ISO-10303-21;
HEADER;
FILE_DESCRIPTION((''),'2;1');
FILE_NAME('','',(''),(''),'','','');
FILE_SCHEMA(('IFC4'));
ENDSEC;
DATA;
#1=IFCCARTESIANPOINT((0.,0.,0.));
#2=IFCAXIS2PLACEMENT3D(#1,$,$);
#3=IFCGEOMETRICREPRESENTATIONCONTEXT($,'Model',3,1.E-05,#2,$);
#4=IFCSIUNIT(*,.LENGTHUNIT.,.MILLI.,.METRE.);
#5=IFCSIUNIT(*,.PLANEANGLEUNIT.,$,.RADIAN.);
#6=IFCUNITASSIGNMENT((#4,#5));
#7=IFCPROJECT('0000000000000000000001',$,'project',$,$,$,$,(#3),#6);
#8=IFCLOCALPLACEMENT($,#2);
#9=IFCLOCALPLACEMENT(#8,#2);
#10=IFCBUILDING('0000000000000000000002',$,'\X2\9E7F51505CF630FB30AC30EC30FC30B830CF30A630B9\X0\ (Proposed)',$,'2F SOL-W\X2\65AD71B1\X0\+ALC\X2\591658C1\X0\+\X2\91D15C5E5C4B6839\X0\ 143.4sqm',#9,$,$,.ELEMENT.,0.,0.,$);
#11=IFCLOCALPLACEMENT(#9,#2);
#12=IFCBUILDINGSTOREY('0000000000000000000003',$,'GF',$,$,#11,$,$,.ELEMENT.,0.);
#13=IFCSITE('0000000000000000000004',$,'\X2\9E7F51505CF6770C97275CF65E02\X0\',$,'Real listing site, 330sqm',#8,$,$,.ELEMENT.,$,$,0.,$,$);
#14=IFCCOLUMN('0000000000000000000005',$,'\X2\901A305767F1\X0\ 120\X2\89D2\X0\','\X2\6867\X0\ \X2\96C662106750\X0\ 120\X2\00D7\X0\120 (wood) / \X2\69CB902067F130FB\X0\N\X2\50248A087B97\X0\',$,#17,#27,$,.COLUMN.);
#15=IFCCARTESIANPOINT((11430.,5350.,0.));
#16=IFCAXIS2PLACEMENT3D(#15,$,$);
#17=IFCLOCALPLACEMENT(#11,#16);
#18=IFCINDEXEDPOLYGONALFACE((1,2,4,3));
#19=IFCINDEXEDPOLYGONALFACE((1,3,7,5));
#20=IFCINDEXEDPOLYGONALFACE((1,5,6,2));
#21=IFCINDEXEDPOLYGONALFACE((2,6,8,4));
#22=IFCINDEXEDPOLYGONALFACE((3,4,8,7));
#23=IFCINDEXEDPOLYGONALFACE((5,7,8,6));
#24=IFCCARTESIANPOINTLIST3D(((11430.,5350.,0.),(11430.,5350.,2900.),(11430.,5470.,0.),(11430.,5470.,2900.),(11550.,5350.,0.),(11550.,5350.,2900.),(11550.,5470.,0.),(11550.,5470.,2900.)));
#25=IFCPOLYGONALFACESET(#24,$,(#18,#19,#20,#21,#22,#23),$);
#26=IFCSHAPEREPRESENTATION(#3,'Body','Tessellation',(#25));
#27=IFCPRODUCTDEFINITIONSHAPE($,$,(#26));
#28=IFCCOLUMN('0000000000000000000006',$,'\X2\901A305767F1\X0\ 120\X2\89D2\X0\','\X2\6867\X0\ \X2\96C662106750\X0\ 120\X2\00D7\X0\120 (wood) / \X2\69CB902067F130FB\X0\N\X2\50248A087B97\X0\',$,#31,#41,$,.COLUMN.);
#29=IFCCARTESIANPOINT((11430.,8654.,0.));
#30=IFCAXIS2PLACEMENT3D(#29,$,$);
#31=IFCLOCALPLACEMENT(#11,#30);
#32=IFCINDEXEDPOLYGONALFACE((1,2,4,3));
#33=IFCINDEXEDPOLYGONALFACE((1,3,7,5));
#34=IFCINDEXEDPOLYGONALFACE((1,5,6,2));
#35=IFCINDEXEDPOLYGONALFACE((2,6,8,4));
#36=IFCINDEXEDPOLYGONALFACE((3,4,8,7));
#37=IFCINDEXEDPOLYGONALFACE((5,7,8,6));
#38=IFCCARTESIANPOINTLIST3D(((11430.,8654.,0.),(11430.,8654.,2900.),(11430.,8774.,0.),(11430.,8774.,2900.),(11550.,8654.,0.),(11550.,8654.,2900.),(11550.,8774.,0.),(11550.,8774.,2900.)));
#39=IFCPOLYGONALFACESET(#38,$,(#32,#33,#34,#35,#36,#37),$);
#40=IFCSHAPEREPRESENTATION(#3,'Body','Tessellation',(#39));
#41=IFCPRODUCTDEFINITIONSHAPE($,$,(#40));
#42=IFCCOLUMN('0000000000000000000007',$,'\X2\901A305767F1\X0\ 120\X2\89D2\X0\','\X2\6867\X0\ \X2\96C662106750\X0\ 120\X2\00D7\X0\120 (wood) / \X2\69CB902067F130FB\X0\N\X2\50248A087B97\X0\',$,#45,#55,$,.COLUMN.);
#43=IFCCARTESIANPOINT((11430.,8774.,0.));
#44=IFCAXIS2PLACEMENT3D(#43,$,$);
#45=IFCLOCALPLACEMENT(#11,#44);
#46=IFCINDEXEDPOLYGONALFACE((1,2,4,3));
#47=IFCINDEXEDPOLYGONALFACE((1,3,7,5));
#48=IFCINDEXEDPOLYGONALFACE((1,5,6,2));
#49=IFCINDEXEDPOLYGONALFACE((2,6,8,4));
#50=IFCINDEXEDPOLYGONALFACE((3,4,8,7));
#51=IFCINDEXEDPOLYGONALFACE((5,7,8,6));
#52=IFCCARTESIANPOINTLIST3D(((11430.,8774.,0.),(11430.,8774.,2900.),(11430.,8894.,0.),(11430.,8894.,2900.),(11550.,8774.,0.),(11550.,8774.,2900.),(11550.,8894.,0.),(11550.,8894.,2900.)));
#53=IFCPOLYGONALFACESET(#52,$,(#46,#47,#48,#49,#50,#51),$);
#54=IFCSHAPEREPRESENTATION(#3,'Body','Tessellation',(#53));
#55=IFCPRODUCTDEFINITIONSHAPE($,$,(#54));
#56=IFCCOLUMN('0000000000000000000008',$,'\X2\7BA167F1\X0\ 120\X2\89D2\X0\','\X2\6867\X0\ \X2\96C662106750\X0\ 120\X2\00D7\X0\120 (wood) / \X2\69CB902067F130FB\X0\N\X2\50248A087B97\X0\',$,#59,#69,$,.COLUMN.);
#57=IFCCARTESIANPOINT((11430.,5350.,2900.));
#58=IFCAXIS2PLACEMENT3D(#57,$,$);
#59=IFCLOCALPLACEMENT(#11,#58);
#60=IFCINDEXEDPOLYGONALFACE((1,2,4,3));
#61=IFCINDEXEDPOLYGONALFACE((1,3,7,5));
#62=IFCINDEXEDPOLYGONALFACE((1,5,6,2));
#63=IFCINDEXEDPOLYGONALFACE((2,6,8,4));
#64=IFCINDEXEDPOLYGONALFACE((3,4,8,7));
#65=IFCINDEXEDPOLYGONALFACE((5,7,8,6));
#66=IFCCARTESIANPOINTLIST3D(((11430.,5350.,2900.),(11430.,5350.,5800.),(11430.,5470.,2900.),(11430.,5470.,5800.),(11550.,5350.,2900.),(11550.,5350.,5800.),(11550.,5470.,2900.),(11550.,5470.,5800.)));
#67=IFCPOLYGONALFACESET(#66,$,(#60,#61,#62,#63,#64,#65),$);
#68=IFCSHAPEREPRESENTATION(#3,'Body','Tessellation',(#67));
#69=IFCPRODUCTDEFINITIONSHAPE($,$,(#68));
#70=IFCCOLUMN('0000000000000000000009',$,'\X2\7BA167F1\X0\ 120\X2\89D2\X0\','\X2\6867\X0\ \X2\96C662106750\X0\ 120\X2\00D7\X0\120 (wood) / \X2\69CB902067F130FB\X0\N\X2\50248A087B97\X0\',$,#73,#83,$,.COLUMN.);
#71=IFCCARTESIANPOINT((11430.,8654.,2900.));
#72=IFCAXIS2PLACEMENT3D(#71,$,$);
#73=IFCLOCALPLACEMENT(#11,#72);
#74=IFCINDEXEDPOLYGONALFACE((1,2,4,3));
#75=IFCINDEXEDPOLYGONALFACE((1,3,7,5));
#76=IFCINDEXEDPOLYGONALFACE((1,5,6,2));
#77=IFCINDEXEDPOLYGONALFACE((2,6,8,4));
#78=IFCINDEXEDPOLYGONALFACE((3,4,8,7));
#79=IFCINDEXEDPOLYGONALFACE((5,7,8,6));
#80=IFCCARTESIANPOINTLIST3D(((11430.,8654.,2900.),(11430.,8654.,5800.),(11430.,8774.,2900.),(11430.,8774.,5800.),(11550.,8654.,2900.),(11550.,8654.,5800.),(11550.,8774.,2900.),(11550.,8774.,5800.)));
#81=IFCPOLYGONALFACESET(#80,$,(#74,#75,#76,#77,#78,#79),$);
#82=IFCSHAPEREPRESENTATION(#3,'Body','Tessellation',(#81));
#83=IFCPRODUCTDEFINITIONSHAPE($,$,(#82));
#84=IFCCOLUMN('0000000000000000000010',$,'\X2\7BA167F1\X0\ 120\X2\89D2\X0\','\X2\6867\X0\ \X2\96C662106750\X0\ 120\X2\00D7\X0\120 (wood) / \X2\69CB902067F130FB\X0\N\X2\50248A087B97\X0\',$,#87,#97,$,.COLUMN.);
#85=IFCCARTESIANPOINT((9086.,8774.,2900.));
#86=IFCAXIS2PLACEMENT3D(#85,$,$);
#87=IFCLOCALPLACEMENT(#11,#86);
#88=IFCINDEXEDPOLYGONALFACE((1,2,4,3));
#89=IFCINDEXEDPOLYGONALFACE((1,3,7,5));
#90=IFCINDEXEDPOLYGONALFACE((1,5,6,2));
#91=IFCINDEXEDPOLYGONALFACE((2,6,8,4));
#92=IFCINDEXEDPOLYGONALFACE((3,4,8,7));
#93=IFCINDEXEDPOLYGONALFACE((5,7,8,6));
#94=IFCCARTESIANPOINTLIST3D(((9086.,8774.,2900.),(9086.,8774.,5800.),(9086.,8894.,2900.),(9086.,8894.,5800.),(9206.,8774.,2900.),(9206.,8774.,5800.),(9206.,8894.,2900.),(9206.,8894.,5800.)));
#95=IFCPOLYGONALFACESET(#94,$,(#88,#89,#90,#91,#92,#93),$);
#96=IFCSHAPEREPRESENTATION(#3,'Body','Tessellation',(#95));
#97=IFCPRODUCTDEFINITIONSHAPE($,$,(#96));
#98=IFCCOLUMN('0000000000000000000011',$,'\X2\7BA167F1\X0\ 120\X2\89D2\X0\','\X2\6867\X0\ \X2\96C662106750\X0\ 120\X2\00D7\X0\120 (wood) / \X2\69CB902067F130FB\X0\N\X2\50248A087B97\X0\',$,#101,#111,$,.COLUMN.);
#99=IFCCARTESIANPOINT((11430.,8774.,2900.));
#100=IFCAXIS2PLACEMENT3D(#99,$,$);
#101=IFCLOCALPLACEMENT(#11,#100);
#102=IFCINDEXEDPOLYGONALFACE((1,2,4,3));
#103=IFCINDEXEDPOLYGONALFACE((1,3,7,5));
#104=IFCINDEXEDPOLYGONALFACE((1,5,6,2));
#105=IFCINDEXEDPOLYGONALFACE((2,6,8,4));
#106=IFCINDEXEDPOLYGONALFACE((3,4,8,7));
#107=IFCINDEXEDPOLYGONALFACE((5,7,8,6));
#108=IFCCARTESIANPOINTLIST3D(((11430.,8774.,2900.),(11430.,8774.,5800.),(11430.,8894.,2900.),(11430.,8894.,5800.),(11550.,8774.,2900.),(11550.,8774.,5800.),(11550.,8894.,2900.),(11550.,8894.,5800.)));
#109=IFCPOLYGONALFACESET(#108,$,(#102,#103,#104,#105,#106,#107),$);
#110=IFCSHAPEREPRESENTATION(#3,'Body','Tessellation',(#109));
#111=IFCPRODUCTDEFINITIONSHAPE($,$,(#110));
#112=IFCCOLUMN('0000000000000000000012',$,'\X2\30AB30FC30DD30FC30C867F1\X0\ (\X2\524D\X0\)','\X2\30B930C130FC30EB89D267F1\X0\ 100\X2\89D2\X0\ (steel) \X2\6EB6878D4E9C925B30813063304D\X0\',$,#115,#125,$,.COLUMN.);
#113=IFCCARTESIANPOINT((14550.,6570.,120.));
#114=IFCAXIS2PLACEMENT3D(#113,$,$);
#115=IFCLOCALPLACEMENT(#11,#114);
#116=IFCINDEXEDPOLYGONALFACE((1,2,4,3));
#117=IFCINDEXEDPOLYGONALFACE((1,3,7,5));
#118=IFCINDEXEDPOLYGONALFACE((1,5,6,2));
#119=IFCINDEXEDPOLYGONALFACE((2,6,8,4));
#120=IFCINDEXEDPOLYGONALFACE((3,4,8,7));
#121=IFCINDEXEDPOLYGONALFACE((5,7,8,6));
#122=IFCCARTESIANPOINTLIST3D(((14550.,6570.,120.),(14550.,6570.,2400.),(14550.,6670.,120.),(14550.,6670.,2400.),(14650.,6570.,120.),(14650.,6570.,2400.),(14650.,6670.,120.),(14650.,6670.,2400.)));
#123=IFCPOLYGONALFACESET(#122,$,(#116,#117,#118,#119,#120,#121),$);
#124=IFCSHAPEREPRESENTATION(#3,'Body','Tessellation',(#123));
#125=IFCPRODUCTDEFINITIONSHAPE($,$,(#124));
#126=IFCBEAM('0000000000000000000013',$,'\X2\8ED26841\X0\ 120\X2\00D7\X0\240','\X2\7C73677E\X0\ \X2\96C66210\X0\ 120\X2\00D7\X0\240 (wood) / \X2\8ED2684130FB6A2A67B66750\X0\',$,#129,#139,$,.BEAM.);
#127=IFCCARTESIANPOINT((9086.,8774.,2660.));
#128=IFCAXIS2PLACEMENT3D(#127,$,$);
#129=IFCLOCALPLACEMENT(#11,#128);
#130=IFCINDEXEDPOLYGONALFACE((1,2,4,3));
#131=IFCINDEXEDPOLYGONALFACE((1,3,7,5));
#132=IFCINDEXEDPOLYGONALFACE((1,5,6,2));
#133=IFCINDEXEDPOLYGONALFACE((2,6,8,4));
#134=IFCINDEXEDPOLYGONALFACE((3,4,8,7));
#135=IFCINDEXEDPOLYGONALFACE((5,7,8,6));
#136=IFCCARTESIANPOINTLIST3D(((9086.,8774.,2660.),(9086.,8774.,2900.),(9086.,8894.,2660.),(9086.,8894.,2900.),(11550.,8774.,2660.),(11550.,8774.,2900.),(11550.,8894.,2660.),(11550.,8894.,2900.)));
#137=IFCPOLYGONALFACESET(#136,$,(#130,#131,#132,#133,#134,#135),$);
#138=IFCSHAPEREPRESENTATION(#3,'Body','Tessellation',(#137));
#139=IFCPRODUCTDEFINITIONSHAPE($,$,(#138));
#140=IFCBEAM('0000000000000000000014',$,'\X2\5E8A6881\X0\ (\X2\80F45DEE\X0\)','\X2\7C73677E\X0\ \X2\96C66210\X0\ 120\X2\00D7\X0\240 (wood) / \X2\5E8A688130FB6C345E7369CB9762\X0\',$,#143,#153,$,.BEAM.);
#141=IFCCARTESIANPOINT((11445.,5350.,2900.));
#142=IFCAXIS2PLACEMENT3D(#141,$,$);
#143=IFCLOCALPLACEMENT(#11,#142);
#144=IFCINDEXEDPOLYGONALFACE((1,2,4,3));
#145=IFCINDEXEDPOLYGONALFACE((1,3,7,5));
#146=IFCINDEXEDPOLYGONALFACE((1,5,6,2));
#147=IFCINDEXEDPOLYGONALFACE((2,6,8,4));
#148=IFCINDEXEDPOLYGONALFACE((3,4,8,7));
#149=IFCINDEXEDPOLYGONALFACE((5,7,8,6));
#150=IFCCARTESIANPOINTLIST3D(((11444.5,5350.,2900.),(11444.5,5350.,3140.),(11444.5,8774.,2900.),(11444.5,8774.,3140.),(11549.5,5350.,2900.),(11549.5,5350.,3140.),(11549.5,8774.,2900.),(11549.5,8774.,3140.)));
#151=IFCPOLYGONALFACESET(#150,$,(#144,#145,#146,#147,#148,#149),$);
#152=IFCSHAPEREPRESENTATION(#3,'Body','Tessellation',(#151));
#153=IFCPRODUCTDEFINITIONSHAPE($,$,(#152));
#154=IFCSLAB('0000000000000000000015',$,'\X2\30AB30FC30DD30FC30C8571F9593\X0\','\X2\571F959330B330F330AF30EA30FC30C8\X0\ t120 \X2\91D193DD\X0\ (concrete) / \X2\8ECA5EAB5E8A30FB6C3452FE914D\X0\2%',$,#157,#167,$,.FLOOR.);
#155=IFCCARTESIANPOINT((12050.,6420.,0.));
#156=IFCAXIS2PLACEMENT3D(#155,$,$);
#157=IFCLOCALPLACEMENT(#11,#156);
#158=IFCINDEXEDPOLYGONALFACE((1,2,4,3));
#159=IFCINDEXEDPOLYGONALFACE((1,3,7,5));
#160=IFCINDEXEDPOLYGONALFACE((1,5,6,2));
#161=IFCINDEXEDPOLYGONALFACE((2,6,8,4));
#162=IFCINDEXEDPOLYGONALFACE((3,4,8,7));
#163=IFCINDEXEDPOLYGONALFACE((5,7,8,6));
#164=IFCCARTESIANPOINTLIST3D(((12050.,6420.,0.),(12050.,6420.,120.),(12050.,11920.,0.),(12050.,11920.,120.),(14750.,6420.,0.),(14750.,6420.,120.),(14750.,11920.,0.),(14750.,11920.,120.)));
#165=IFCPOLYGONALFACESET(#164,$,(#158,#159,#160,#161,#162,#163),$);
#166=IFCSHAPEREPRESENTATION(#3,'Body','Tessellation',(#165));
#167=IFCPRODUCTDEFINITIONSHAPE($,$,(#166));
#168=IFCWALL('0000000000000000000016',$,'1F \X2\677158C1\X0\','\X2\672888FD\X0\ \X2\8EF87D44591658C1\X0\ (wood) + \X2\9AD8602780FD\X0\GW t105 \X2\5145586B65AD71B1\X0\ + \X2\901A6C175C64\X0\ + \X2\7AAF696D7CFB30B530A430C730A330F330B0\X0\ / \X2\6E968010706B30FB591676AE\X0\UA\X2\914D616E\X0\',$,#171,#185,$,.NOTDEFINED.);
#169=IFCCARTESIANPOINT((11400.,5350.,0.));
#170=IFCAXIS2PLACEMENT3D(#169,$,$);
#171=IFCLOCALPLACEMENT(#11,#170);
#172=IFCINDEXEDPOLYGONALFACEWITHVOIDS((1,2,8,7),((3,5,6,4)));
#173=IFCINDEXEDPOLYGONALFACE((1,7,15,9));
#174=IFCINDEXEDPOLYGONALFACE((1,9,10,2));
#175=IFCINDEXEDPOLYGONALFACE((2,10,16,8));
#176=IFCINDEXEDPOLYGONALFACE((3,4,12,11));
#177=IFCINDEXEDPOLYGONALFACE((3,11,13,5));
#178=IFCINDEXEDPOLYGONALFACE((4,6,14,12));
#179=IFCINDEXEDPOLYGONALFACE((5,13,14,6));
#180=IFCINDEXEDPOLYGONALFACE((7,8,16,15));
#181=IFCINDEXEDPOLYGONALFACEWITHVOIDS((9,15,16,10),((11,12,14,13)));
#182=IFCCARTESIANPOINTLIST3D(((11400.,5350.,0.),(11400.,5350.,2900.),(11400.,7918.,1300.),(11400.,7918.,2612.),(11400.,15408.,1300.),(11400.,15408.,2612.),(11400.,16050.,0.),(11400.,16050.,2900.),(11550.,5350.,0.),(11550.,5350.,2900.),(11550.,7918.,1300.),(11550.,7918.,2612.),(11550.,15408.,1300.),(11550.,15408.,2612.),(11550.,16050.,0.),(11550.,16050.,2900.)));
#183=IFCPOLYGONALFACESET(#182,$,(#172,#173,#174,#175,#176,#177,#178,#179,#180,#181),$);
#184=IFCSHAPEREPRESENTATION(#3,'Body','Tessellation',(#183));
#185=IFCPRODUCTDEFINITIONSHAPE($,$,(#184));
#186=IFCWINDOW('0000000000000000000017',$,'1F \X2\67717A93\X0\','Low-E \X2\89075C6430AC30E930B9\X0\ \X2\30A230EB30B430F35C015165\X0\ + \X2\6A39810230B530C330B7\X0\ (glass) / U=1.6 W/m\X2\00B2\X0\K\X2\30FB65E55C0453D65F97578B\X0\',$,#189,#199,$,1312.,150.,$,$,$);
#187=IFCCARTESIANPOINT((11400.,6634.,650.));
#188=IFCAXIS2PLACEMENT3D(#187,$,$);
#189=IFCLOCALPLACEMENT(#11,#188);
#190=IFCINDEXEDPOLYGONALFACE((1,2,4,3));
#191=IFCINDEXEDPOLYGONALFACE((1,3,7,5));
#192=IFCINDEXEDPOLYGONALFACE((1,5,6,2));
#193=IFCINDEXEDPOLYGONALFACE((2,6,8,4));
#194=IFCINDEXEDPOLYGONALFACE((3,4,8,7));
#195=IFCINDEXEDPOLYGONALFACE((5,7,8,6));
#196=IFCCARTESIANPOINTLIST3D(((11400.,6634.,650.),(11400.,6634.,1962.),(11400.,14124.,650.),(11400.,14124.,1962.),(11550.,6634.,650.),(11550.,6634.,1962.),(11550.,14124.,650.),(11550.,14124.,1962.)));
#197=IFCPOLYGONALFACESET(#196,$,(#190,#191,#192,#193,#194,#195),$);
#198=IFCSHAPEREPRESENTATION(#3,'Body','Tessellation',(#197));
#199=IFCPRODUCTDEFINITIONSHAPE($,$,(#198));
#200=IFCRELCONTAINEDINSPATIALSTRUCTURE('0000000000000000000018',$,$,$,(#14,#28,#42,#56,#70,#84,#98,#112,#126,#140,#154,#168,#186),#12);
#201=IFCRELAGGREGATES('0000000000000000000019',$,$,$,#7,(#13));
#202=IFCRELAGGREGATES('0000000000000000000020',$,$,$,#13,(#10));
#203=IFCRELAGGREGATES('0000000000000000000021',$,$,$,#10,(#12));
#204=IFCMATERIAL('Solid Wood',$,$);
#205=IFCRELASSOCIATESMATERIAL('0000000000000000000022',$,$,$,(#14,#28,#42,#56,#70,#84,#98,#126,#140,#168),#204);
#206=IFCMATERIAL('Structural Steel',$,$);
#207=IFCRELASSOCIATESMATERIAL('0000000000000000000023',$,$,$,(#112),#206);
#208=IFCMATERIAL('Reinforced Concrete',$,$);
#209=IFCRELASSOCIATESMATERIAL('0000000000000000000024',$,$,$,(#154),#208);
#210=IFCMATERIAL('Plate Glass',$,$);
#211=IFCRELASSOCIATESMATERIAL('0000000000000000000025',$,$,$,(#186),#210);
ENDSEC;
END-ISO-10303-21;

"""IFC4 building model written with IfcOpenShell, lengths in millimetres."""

from ifc_helpers import new_model, si_unit, frame, frame_2d, origin, place, context, project, spatial, rectangle, extrude, material, element, fill, save


model = new_model("IFC4")

# Units and contexts
model_context = context("Model", 3, precision=1e-05, world=origin())
ifc_project = project(units=[si_unit("LENGTHUNIT", "METRE", prefix="MILLI"), si_unit("PLANEANGLEUNIT", "RADIAN")], contexts=[model_context])

# Site, building, storey
site_placement = place(None, origin())
site = spatial("IfcSite", under=ifc_project, at=site_placement, Name="鹿児島県霧島市", ObjectType="Real listing site, 330sqm", CompositionType="ELEMENT", RefElevation=0.0)
building_placement = place(site_placement, origin())
building = spatial("IfcBuilding", under=site, at=building_placement, Name="鹿児島・ガレージハウス (Proposed)", ObjectType="2F SOL-W断熱+ALC外壁+金属屋根 143.4sqm", CompositionType="ELEMENT", ElevationOfRefHeight=0.0, ElevationOfTerrain=0.0)
storey_placement = place(building_placement, origin())
storey = spatial("IfcBuildingStorey", under=building, at=storey_placement, Name="GF", CompositionType="ELEMENT", Elevation=0.0)

# Columns
ifc_material_1 = material(Name="Solid Wood")
column_1_placement = place(storey_placement, frame((11430.0, 5350.0, 0.0)))
element("IfcColumn", 1, at=column_1_placement, inside=storey, material=ifc_material_1, Name="通し柱 120角", Description="桧 集成材 120×120 (wood) / 構造柱・N値計算", PredefinedType="COLUMN", context=model_context, shape_type="SweptSolid", body=[
    extrude(rectangle(XDim=120.0, YDim=120.0, at=frame_2d((60.0, 60.0))), frame((11430.0, 5350.0, 0.0)), (0.0, 0.0, 1.0), 2900.0),
])
column_2_placement = place(storey_placement, frame((11430.0, 8654.0, 0.0)))
element("IfcColumn", 2, at=column_2_placement, inside=storey, material=ifc_material_1, Name="通し柱 120角", Description="桧 集成材 120×120 (wood) / 構造柱・N値計算", PredefinedType="COLUMN", context=model_context, shape_type="SweptSolid", body=[
    extrude(rectangle(XDim=120.0, YDim=120.0, at=frame_2d((60.0, 60.0))), frame((11430.0, 8654.0, 0.0)), (0.0, 0.0, 1.0), 2900.0),
])
column_3_placement = place(storey_placement, frame((11430.0, 8774.0, 0.0)))
element("IfcColumn", 3, at=column_3_placement, inside=storey, material=ifc_material_1, Name="通し柱 120角", Description="桧 集成材 120×120 (wood) / 構造柱・N値計算", PredefinedType="COLUMN", context=model_context, shape_type="SweptSolid", body=[
    extrude(rectangle(XDim=120.0, YDim=120.0, at=frame_2d((60.0, 60.0))), frame((11430.0, 8774.0, 0.0)), (0.0, 0.0, 1.0), 2900.0),
])
column_4_placement = place(storey_placement, frame((11430.0, 5350.0, 2900.0)))
element("IfcColumn", 4, at=column_4_placement, inside=storey, material=ifc_material_1, Name="管柱 120角", Description="桧 集成材 120×120 (wood) / 構造柱・N値計算", PredefinedType="COLUMN", context=model_context, shape_type="SweptSolid", body=[
    extrude(rectangle(XDim=120.0, YDim=120.0, at=frame_2d((60.0, 60.0))), frame((11430.0, 5350.0, 2900.0)), (0.0, 0.0, 1.0), 2900.0),
])
column_5_placement = place(storey_placement, frame((11430.0, 8654.0, 2900.0)))
element("IfcColumn", 5, at=column_5_placement, inside=storey, material=ifc_material_1, Name="管柱 120角", Description="桧 集成材 120×120 (wood) / 構造柱・N値計算", PredefinedType="COLUMN", context=model_context, shape_type="SweptSolid", body=[
    extrude(rectangle(XDim=120.0, YDim=120.0, at=frame_2d((60.0, 60.0))), frame((11430.0, 8654.0, 2900.0)), (0.0, 0.0, 1.0), 2900.0),
])
column_6_placement = place(storey_placement, frame((9086.0, 8774.0, 2900.0)))
element("IfcColumn", 6, at=column_6_placement, inside=storey, material=ifc_material_1, Name="管柱 120角", Description="桧 集成材 120×120 (wood) / 構造柱・N値計算", PredefinedType="COLUMN", context=model_context, shape_type="SweptSolid", body=[
    extrude(rectangle(XDim=120.0, YDim=120.0, at=frame_2d((60.0, 60.0))), frame((9086.0, 8774.0, 2900.0)), (0.0, 0.0, 1.0), 2900.0),
])
column_7_placement = place(storey_placement, frame((11430.0, 8774.0, 2900.0)))
element("IfcColumn", 7, at=column_7_placement, inside=storey, material=ifc_material_1, Name="管柱 120角", Description="桧 集成材 120×120 (wood) / 構造柱・N値計算", PredefinedType="COLUMN", context=model_context, shape_type="SweptSolid", body=[
    extrude(rectangle(XDim=120.0, YDim=120.0, at=frame_2d((60.0, 60.0))), frame((11430.0, 8774.0, 2900.0)), (0.0, 0.0, 1.0), 2900.0),
])
ifc_material_2 = material(Name="Structural Steel")
column_8_placement = place(storey_placement, frame((14550.0, 6570.0, 120.0)))
element("IfcColumn", 8, at=column_8_placement, inside=storey, material=ifc_material_2, Name="カーポート柱 (前)", Description="スチール角柱 100角 (steel) 溶融亜鉛めっき", PredefinedType="COLUMN", context=model_context, shape_type="SweptSolid", body=[
    extrude(rectangle(XDim=100.0, YDim=100.0, at=frame_2d((50.0, 50.0))), frame((14550.0, 6570.0, 120.0)), (0.0, 0.0, 1.0), 2280.0),
])

# Beams
beam_1_placement = place(storey_placement, frame((9086.0, 8774.0, 2660.0)))
element("IfcBeam", 9, at=beam_1_placement, inside=storey, material=ifc_material_1, Name="軒桁 120×240", Description="米松 集成 120×240 (wood) / 軒桁・横架材", PredefinedType="BEAM", context=model_context, shape_type="SweptSolid", body=[
    extrude(rectangle(XDim=2464.0, YDim=120.0, at=frame_2d((1232.0, 60.0))), frame((9086.0, 8774.0, 2660.0)), (0.0, 0.0, 1.0), 240.0),
])
beam_2_placement = place(storey_placement, frame((11445.0, 5350.0, 2900.0)))
element("IfcBeam", 10, at=beam_2_placement, inside=storey, material=ifc_material_1, Name="床梁 (胴差)", Description="米松 集成 120×240 (wood) / 床梁・水平構面", PredefinedType="BEAM", context=model_context, shape_type="SweptSolid", body=[
    extrude(rectangle(XDim=105.0, YDim=3424.0, at=frame_2d((52.0, 1712.0))), frame((11445.0, 5350.0, 2900.0)), (0.0, 0.0, 1.0), 240.0),
])

# Slab
ifc_material_3 = material(Name="Reinforced Concrete")
slab_placement = place(storey_placement, frame((12050.0, 6420.0, 0.0)))
element("IfcSlab", 11, at=slab_placement, inside=storey, material=ifc_material_3, Name="カーポート土間", Description="土間コンクリート t120 金鏝 (concrete) / 車庫床・水勾配2%", PredefinedType="FLOOR", context=model_context, shape_type="SweptSolid", body=[
    extrude(rectangle(XDim=2700.0, YDim=5500.0, at=frame_2d((1350.0, 2750.0))), frame((12050.0, 6420.0, 0.0)), (0.0, 0.0, 1.0), 120.0),
])

# Wall, opening, window
wall_1_placement = place(storey_placement, frame((11400.0, 5350.0, 0.0)))
wall_1 = element("IfcWall", 12, at=wall_1_placement, inside=storey, material=ifc_material_1, Name="1F 東壁", Description="木製 軸組外壁 (wood) + 高性能GW t105 充填断熱 + 通気層 + 窯業系サイディング / 準耐火・外皮UA配慮", PredefinedType="NOTDEFINED", context=model_context, shape_type="SweptSolid", body=[
    extrude(rectangle(XDim=150.0, YDim=10700.0, at=frame_2d((75.0, 5350.0))), frame((11400.0, 5350.0, 0.0)), (0.0, 0.0, 1.0), 2900.0),
])
opening_1_placement = place(storey_placement, frame((11400.0, 6634.0, 650.0)))
opening_1 = element("IfcOpeningElement", 13, at=opening_1_placement, cuts=wall_1, PredefinedType="NOTDEFINED", context=model_context, shape_type="SweptSolid", body=[
    extrude(rectangle(XDim=150.0, YDim=7490.0, at=frame_2d((75.0, 3745.0))), frame((11400.0, 6634.0, 650.0)), (0.0, 0.0, 1.0), 1312.0),
])
ifc_material_4 = material(Name="Plate Glass")
window_1_placement = place(storey_placement, frame((11400.0, 6634.0, 650.0)))
window_1 = element("IfcWindow", 14, at=window_1_placement, inside=storey, material=ifc_material_4, Name="1F 東窓", Description="Low-E 複層ガラス アルゴン封入 + 樹脂サッシ (glass) / U=1.6 W/m²K・日射取得型", OverallHeight=1312.0, OverallWidth=150.0, context=model_context, shape_type="SweptSolid", body=[
    extrude(rectangle(XDim=150.0, YDim=7490.0, at=frame_2d((75.0, 3745.0))), frame((11400.0, 6634.0, 650.0)), (0.0, 0.0, 1.0), 1312.0),
])
fill(opening_1, window_1)

save(model, "model.ifc")
